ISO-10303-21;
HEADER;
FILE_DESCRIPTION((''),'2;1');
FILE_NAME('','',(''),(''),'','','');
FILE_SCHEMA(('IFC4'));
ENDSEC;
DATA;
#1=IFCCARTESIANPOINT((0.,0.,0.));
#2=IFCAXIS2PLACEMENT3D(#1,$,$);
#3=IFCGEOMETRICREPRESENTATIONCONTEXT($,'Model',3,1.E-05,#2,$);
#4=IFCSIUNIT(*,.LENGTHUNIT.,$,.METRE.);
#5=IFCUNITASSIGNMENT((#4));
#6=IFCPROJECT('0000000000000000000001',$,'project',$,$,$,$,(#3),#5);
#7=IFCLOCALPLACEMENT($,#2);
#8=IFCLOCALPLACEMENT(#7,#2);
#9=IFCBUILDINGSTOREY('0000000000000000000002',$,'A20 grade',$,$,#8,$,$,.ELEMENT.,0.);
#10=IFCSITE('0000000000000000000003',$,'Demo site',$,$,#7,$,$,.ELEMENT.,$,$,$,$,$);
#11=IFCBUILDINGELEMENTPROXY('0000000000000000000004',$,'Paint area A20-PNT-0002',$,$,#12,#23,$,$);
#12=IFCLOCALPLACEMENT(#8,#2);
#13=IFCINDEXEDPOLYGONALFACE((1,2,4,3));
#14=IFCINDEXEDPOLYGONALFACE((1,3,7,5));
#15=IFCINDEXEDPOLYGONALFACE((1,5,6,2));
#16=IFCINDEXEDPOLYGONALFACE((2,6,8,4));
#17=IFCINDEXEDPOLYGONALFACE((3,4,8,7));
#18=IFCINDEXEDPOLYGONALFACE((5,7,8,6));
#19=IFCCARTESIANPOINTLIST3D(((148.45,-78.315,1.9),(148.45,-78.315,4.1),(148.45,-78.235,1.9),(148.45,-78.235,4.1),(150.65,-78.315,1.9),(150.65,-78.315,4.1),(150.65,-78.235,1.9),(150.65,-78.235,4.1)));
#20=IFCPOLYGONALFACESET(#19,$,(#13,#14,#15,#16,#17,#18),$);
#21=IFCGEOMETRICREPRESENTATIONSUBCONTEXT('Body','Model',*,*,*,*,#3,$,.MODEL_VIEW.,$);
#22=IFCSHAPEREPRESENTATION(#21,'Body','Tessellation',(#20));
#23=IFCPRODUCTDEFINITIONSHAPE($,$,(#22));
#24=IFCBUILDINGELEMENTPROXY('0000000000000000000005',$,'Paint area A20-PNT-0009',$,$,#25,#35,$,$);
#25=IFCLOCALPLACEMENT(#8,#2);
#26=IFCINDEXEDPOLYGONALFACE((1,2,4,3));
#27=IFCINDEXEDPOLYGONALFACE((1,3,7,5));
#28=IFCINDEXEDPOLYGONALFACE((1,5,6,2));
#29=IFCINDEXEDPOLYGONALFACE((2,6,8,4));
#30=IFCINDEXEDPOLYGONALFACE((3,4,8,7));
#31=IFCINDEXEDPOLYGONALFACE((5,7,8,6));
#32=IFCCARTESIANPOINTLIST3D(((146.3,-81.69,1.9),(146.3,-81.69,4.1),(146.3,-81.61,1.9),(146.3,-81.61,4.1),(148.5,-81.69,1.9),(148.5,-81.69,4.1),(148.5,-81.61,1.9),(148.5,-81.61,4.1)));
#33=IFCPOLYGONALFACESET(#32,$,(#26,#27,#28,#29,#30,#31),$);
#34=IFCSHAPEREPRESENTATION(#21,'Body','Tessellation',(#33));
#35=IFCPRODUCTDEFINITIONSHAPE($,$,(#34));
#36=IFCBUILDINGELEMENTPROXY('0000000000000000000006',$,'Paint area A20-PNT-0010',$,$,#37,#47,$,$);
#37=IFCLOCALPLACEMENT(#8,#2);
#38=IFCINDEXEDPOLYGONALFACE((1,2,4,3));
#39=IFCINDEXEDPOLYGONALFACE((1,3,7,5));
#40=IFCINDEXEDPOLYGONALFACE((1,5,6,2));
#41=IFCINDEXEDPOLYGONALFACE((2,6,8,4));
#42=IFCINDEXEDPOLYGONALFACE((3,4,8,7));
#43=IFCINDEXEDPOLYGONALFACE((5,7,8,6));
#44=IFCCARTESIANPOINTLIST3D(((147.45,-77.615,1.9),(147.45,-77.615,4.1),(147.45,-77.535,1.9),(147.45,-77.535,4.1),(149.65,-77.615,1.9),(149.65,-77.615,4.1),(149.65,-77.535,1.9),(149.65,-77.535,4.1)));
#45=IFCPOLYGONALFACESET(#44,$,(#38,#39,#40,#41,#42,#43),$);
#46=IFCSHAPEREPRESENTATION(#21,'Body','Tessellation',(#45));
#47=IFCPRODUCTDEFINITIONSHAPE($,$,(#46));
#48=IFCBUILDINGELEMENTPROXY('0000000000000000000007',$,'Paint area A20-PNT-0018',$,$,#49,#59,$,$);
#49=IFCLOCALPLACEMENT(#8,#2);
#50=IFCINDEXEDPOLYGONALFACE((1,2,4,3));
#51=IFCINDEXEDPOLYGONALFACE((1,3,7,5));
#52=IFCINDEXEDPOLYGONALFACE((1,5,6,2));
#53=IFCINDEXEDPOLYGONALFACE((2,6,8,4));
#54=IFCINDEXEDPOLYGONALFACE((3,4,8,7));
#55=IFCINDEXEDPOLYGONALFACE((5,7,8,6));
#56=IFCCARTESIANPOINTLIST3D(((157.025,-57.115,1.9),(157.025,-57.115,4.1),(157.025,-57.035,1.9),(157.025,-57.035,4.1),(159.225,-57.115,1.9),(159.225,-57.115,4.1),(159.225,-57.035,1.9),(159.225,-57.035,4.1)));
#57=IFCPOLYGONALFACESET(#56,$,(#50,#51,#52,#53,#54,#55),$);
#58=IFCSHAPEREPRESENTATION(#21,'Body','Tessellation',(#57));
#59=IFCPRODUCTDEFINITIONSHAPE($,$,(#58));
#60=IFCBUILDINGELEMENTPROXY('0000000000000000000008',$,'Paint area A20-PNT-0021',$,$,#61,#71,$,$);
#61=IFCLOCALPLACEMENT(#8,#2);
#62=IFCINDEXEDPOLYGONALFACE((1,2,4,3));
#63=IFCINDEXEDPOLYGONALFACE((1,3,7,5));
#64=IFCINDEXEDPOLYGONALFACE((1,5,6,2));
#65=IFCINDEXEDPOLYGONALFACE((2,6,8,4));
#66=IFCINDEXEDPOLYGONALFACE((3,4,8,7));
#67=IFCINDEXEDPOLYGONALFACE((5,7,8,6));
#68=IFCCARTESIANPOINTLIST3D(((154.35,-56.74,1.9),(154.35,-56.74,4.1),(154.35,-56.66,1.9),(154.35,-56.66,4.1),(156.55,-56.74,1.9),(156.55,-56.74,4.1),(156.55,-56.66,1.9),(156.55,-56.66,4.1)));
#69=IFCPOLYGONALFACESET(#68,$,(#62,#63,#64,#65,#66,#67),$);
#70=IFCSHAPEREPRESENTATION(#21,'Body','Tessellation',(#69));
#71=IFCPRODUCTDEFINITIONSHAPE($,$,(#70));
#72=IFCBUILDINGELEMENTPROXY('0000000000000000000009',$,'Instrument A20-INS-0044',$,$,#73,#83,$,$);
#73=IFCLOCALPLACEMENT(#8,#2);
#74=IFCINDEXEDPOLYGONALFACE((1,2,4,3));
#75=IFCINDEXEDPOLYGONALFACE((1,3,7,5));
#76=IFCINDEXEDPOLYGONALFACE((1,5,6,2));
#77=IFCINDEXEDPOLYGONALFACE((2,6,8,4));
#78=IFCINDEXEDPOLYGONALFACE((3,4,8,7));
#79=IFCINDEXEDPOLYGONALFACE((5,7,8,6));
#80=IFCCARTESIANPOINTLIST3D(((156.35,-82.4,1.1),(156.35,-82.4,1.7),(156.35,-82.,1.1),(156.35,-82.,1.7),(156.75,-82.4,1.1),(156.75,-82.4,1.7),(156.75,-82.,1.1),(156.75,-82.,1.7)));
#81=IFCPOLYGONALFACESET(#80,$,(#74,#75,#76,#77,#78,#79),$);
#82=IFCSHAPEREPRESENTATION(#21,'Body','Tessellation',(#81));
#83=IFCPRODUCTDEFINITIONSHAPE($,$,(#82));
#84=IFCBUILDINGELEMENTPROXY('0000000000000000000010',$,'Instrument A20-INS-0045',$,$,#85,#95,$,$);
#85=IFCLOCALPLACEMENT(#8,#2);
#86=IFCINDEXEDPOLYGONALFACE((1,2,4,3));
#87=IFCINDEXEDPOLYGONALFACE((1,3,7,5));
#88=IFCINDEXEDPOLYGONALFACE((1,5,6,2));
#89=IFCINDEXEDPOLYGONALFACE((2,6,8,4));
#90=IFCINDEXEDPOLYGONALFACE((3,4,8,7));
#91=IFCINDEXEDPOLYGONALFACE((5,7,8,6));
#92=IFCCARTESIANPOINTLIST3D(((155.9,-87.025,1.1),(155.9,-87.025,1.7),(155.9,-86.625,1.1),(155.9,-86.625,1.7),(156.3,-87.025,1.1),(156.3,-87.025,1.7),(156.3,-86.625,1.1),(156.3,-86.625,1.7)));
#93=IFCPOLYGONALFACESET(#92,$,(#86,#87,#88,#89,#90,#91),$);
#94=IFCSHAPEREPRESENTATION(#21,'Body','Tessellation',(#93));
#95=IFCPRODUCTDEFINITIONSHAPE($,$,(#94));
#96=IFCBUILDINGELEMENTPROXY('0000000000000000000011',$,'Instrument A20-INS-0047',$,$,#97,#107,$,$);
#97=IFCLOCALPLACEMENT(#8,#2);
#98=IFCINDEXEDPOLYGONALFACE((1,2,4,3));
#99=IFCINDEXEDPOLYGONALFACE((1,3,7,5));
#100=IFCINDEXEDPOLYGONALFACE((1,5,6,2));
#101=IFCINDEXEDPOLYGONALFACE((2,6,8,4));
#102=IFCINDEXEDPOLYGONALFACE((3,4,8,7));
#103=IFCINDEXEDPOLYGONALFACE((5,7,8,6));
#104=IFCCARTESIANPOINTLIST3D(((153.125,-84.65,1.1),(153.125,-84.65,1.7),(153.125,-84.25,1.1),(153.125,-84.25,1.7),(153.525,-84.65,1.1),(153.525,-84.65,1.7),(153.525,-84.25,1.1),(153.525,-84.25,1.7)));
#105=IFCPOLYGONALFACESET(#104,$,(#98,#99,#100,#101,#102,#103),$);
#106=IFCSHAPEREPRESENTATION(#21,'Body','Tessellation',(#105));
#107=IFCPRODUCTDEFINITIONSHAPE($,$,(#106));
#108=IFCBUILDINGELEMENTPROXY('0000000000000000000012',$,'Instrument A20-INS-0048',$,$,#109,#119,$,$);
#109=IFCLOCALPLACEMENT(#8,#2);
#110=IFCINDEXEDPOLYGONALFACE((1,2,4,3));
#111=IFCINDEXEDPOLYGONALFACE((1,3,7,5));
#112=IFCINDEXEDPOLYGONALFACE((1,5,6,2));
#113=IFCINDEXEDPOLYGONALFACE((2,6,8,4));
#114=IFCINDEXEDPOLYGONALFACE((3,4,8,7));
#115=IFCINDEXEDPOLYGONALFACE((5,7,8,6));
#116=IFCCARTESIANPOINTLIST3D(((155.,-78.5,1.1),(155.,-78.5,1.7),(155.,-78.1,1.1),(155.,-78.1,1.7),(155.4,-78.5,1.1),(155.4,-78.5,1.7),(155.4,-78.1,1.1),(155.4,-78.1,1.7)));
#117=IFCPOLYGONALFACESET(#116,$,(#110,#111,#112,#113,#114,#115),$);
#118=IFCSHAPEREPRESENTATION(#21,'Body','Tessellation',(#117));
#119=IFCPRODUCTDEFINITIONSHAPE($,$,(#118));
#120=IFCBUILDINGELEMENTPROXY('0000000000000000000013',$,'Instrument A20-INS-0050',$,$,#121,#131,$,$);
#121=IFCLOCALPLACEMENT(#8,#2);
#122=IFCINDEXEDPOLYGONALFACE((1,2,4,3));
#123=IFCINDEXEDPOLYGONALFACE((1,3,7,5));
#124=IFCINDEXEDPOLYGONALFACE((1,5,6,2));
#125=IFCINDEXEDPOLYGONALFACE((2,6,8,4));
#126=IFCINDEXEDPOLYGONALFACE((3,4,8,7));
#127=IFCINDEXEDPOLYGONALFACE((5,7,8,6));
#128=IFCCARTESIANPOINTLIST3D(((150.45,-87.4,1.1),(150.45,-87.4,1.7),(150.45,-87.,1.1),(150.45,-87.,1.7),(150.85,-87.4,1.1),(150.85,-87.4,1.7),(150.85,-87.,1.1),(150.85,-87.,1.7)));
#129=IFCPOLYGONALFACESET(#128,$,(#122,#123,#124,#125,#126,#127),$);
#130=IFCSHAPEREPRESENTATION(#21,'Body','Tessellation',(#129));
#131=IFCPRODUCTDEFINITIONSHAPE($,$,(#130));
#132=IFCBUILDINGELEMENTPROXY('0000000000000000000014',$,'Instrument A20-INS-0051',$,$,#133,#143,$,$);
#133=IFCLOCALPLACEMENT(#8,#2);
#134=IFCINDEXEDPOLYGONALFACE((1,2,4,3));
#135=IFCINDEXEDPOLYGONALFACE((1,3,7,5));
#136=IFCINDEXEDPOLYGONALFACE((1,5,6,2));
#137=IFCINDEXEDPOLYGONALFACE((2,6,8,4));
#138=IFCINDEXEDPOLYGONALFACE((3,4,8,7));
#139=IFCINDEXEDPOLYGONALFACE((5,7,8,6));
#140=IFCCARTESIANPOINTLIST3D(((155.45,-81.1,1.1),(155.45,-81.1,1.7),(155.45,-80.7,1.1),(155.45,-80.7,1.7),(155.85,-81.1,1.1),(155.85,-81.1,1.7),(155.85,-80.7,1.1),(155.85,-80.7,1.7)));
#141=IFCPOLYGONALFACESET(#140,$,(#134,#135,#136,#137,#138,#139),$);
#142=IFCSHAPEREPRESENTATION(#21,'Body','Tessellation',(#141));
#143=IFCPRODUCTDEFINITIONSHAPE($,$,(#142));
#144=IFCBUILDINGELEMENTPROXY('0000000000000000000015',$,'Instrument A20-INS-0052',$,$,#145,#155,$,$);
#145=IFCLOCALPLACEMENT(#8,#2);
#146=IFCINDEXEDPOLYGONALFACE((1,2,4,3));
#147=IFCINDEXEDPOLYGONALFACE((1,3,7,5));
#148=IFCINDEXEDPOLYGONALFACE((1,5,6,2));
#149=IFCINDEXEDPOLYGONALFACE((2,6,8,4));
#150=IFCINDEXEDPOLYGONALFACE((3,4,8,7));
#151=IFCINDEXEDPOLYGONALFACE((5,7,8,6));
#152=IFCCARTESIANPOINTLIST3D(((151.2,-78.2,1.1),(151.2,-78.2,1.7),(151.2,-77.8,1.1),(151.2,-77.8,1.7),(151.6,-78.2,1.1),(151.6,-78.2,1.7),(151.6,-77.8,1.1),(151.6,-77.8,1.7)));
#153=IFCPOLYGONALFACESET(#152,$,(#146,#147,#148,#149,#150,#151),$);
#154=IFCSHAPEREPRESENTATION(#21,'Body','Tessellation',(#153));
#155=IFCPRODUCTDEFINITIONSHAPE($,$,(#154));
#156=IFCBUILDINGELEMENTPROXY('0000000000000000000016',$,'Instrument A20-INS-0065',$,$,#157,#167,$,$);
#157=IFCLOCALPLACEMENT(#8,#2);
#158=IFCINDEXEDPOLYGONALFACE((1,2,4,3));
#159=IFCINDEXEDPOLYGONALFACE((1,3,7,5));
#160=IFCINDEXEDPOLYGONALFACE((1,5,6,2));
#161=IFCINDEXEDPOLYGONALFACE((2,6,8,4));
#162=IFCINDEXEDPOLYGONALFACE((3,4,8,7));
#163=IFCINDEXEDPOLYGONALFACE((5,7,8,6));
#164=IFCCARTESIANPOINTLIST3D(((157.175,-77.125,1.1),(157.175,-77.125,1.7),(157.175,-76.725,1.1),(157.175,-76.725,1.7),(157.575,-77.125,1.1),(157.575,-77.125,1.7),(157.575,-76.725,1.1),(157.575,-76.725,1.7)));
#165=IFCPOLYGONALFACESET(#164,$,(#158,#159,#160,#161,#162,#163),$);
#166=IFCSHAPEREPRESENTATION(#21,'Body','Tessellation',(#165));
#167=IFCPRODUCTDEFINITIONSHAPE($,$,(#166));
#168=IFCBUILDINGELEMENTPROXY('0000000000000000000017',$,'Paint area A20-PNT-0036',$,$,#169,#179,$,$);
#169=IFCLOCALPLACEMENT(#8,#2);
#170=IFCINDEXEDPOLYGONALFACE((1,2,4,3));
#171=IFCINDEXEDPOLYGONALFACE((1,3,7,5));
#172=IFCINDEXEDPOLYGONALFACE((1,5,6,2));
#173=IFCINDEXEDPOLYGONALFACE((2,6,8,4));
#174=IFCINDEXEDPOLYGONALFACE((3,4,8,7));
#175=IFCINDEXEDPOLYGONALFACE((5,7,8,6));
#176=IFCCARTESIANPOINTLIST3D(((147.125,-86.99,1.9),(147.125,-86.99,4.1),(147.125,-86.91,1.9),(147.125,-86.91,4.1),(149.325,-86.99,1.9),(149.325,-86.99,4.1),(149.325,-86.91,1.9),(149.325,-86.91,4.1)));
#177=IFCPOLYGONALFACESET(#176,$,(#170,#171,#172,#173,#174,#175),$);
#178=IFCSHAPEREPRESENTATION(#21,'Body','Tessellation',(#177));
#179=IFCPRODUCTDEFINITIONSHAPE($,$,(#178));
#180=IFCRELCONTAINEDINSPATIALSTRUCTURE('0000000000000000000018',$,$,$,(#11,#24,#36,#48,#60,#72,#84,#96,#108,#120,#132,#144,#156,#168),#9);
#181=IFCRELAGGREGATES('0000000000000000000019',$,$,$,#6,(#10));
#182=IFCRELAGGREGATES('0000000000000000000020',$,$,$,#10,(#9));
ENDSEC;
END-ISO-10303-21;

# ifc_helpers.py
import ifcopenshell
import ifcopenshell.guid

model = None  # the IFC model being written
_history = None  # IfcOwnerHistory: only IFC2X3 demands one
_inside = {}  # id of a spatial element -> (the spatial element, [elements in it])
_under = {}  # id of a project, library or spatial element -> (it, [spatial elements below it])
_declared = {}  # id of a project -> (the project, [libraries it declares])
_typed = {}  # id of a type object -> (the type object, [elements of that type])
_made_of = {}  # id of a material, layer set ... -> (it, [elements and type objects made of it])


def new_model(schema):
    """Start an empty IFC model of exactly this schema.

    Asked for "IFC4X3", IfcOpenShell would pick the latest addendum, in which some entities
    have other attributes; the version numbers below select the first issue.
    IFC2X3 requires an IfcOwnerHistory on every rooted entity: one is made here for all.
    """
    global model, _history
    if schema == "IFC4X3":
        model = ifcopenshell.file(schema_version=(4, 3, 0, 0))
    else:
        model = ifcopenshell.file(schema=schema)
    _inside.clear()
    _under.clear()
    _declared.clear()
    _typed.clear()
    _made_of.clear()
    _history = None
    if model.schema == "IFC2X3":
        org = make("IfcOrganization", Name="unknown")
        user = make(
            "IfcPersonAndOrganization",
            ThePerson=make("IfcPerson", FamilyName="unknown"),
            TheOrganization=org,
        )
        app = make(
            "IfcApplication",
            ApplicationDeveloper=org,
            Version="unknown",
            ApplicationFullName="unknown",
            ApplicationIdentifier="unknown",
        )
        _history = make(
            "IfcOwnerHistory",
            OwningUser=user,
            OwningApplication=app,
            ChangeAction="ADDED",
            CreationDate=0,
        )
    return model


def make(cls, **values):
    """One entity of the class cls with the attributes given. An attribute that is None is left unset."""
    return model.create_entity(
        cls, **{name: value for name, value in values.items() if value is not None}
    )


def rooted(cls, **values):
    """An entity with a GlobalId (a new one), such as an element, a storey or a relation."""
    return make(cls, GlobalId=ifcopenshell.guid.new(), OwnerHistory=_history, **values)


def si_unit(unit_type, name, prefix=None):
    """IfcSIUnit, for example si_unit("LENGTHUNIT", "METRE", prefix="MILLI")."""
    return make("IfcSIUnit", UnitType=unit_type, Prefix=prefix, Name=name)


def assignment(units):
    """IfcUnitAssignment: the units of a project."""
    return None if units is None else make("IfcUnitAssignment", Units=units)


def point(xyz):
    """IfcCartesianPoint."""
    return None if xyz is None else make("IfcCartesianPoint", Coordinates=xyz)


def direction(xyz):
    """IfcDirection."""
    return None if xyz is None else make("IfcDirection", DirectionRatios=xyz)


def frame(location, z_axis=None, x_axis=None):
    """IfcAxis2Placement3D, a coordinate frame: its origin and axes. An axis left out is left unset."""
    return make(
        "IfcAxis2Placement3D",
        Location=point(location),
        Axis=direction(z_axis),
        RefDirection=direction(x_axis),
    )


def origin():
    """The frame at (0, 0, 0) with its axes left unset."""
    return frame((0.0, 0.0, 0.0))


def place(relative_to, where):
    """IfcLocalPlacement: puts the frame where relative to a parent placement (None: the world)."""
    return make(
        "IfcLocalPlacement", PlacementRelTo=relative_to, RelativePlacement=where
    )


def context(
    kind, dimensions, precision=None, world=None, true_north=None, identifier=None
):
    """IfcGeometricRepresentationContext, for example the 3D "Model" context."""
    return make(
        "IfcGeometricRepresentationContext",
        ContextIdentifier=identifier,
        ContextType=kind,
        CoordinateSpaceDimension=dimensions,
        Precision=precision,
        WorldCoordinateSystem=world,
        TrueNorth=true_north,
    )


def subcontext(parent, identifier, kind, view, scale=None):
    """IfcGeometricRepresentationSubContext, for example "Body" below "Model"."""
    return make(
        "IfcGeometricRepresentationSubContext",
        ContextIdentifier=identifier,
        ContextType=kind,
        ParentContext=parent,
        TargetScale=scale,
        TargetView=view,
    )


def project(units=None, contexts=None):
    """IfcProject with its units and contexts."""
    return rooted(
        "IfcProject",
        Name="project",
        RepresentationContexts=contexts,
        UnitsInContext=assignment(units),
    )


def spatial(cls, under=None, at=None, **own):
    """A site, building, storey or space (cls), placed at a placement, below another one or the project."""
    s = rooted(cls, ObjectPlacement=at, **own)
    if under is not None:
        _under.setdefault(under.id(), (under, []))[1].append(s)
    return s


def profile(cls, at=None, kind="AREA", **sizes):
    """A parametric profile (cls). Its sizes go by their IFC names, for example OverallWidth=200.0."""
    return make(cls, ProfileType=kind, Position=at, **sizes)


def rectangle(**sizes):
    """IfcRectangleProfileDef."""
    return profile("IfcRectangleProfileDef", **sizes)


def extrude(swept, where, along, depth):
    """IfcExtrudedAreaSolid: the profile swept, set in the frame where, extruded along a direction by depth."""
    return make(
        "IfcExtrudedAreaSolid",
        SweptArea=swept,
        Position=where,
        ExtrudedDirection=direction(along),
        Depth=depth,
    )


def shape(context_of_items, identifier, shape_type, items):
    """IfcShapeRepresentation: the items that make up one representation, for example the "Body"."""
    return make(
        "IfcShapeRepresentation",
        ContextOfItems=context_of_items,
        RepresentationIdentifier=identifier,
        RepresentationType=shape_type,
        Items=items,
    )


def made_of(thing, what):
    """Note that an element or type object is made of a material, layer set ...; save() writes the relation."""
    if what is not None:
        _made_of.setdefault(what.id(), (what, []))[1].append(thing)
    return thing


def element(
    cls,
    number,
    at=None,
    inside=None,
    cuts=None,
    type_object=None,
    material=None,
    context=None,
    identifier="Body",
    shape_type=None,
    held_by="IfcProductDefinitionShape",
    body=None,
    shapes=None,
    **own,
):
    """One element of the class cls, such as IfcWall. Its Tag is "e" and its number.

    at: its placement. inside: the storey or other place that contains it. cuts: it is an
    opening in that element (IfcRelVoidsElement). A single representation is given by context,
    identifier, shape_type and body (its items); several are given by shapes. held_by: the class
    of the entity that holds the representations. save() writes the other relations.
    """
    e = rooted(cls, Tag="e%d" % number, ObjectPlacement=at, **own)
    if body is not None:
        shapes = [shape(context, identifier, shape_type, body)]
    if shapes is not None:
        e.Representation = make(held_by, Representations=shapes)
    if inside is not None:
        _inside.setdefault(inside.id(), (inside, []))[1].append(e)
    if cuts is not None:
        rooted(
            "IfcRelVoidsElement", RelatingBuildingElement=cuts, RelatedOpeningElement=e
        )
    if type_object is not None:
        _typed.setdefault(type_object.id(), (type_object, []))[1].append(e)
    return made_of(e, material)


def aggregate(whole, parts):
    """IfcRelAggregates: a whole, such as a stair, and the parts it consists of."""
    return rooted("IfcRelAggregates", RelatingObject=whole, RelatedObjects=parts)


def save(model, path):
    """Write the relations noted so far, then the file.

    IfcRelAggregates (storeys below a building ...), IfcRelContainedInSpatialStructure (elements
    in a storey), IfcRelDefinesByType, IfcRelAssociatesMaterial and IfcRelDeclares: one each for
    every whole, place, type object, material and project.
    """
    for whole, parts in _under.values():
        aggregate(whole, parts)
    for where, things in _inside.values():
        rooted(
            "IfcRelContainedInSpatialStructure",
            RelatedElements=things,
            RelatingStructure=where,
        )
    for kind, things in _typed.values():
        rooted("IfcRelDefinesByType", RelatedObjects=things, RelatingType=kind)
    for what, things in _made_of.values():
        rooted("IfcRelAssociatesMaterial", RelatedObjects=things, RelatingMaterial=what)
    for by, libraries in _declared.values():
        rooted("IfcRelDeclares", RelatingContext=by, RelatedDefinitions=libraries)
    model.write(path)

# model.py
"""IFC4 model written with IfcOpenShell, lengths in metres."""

from ifc_helpers import new_model, si_unit, frame, origin, place, context, subcontext, project, spatial, rectangle, extrude, element, save


model = new_model("IFC4")

# Units and contexts
model_context = context("Model", 3, precision=1e-05, world=origin())
body_context = subcontext(model_context, "Body", "Model", "MODEL_VIEW")
ifc_project = project(units=[si_unit("LENGTHUNIT", "METRE")], contexts=[model_context])

# Site, storey
site_placement = place(None, origin())
site = spatial("IfcSite", under=ifc_project, at=site_placement, Name="Demo site", CompositionType="ELEMENT")
storey_placement = place(site_placement, origin())
storey = spatial("IfcBuildingStorey", under=site, at=storey_placement, Name="A20 grade", CompositionType="ELEMENT", Elevation=0.0)

# Building element proxies
for number, where, name in (
    (1, (149.55, -78.275, 1.9), "Paint area A20-PNT-0002"),
    (2, (147.4, -81.65, 1.9), "Paint area A20-PNT-0009"),
    (3, (148.55, -77.575, 1.9), "Paint area A20-PNT-0010"),
    (4, (158.125, -57.075, 1.9), "Paint area A20-PNT-0018"),
    (5, (155.45, -56.7, 1.9), "Paint area A20-PNT-0021"),
):
    element("IfcBuildingElementProxy", number, at=place(storey_placement, frame(where)), inside=storey, Name=name, context=body_context, shape_type="SweptSolid", body=[
        extrude(rectangle(XDim=2.2, YDim=0.08), origin(), (0.0, 0.0, 1.0), 2.2),
    ])
for number, where, name in (
    (6, (156.55, -82.2, 1.1), "Instrument A20-INS-0044"),
    (7, (156.1, -86.825, 1.1), "Instrument A20-INS-0045"),
    (8, (153.325, -84.45, 1.1), "Instrument A20-INS-0047"),
    (9, (155.2, -78.3, 1.1), "Instrument A20-INS-0048"),
    (10, (150.65, -87.2, 1.1), "Instrument A20-INS-0050"),
    (11, (155.65, -80.9, 1.1), "Instrument A20-INS-0051"),
    (12, (151.4, -78.0, 1.1), "Instrument A20-INS-0052"),
    (13, (157.375, -76.925, 1.1), "Instrument A20-INS-0065"),
):
    element("IfcBuildingElementProxy", number, at=place(storey_placement, frame(where)), inside=storey, Name=name, context=body_context, shape_type="SweptSolid", body=[
        extrude(rectangle(XDim=0.4, YDim=0.4), origin(), (0.0, 0.0, 1.0), 0.6),
    ])
proxy_placement = place(storey_placement, frame((148.225, -86.95, 1.9)))
element("IfcBuildingElementProxy", 14, at=proxy_placement, inside=storey, Name="Paint area A20-PNT-0036", context=body_context, shape_type="SweptSolid", body=[
    extrude(rectangle(XDim=2.2, YDim=0.08), origin(), (0.0, 0.0, 1.0), 2.2),
])

save(model, "model.ifc")
